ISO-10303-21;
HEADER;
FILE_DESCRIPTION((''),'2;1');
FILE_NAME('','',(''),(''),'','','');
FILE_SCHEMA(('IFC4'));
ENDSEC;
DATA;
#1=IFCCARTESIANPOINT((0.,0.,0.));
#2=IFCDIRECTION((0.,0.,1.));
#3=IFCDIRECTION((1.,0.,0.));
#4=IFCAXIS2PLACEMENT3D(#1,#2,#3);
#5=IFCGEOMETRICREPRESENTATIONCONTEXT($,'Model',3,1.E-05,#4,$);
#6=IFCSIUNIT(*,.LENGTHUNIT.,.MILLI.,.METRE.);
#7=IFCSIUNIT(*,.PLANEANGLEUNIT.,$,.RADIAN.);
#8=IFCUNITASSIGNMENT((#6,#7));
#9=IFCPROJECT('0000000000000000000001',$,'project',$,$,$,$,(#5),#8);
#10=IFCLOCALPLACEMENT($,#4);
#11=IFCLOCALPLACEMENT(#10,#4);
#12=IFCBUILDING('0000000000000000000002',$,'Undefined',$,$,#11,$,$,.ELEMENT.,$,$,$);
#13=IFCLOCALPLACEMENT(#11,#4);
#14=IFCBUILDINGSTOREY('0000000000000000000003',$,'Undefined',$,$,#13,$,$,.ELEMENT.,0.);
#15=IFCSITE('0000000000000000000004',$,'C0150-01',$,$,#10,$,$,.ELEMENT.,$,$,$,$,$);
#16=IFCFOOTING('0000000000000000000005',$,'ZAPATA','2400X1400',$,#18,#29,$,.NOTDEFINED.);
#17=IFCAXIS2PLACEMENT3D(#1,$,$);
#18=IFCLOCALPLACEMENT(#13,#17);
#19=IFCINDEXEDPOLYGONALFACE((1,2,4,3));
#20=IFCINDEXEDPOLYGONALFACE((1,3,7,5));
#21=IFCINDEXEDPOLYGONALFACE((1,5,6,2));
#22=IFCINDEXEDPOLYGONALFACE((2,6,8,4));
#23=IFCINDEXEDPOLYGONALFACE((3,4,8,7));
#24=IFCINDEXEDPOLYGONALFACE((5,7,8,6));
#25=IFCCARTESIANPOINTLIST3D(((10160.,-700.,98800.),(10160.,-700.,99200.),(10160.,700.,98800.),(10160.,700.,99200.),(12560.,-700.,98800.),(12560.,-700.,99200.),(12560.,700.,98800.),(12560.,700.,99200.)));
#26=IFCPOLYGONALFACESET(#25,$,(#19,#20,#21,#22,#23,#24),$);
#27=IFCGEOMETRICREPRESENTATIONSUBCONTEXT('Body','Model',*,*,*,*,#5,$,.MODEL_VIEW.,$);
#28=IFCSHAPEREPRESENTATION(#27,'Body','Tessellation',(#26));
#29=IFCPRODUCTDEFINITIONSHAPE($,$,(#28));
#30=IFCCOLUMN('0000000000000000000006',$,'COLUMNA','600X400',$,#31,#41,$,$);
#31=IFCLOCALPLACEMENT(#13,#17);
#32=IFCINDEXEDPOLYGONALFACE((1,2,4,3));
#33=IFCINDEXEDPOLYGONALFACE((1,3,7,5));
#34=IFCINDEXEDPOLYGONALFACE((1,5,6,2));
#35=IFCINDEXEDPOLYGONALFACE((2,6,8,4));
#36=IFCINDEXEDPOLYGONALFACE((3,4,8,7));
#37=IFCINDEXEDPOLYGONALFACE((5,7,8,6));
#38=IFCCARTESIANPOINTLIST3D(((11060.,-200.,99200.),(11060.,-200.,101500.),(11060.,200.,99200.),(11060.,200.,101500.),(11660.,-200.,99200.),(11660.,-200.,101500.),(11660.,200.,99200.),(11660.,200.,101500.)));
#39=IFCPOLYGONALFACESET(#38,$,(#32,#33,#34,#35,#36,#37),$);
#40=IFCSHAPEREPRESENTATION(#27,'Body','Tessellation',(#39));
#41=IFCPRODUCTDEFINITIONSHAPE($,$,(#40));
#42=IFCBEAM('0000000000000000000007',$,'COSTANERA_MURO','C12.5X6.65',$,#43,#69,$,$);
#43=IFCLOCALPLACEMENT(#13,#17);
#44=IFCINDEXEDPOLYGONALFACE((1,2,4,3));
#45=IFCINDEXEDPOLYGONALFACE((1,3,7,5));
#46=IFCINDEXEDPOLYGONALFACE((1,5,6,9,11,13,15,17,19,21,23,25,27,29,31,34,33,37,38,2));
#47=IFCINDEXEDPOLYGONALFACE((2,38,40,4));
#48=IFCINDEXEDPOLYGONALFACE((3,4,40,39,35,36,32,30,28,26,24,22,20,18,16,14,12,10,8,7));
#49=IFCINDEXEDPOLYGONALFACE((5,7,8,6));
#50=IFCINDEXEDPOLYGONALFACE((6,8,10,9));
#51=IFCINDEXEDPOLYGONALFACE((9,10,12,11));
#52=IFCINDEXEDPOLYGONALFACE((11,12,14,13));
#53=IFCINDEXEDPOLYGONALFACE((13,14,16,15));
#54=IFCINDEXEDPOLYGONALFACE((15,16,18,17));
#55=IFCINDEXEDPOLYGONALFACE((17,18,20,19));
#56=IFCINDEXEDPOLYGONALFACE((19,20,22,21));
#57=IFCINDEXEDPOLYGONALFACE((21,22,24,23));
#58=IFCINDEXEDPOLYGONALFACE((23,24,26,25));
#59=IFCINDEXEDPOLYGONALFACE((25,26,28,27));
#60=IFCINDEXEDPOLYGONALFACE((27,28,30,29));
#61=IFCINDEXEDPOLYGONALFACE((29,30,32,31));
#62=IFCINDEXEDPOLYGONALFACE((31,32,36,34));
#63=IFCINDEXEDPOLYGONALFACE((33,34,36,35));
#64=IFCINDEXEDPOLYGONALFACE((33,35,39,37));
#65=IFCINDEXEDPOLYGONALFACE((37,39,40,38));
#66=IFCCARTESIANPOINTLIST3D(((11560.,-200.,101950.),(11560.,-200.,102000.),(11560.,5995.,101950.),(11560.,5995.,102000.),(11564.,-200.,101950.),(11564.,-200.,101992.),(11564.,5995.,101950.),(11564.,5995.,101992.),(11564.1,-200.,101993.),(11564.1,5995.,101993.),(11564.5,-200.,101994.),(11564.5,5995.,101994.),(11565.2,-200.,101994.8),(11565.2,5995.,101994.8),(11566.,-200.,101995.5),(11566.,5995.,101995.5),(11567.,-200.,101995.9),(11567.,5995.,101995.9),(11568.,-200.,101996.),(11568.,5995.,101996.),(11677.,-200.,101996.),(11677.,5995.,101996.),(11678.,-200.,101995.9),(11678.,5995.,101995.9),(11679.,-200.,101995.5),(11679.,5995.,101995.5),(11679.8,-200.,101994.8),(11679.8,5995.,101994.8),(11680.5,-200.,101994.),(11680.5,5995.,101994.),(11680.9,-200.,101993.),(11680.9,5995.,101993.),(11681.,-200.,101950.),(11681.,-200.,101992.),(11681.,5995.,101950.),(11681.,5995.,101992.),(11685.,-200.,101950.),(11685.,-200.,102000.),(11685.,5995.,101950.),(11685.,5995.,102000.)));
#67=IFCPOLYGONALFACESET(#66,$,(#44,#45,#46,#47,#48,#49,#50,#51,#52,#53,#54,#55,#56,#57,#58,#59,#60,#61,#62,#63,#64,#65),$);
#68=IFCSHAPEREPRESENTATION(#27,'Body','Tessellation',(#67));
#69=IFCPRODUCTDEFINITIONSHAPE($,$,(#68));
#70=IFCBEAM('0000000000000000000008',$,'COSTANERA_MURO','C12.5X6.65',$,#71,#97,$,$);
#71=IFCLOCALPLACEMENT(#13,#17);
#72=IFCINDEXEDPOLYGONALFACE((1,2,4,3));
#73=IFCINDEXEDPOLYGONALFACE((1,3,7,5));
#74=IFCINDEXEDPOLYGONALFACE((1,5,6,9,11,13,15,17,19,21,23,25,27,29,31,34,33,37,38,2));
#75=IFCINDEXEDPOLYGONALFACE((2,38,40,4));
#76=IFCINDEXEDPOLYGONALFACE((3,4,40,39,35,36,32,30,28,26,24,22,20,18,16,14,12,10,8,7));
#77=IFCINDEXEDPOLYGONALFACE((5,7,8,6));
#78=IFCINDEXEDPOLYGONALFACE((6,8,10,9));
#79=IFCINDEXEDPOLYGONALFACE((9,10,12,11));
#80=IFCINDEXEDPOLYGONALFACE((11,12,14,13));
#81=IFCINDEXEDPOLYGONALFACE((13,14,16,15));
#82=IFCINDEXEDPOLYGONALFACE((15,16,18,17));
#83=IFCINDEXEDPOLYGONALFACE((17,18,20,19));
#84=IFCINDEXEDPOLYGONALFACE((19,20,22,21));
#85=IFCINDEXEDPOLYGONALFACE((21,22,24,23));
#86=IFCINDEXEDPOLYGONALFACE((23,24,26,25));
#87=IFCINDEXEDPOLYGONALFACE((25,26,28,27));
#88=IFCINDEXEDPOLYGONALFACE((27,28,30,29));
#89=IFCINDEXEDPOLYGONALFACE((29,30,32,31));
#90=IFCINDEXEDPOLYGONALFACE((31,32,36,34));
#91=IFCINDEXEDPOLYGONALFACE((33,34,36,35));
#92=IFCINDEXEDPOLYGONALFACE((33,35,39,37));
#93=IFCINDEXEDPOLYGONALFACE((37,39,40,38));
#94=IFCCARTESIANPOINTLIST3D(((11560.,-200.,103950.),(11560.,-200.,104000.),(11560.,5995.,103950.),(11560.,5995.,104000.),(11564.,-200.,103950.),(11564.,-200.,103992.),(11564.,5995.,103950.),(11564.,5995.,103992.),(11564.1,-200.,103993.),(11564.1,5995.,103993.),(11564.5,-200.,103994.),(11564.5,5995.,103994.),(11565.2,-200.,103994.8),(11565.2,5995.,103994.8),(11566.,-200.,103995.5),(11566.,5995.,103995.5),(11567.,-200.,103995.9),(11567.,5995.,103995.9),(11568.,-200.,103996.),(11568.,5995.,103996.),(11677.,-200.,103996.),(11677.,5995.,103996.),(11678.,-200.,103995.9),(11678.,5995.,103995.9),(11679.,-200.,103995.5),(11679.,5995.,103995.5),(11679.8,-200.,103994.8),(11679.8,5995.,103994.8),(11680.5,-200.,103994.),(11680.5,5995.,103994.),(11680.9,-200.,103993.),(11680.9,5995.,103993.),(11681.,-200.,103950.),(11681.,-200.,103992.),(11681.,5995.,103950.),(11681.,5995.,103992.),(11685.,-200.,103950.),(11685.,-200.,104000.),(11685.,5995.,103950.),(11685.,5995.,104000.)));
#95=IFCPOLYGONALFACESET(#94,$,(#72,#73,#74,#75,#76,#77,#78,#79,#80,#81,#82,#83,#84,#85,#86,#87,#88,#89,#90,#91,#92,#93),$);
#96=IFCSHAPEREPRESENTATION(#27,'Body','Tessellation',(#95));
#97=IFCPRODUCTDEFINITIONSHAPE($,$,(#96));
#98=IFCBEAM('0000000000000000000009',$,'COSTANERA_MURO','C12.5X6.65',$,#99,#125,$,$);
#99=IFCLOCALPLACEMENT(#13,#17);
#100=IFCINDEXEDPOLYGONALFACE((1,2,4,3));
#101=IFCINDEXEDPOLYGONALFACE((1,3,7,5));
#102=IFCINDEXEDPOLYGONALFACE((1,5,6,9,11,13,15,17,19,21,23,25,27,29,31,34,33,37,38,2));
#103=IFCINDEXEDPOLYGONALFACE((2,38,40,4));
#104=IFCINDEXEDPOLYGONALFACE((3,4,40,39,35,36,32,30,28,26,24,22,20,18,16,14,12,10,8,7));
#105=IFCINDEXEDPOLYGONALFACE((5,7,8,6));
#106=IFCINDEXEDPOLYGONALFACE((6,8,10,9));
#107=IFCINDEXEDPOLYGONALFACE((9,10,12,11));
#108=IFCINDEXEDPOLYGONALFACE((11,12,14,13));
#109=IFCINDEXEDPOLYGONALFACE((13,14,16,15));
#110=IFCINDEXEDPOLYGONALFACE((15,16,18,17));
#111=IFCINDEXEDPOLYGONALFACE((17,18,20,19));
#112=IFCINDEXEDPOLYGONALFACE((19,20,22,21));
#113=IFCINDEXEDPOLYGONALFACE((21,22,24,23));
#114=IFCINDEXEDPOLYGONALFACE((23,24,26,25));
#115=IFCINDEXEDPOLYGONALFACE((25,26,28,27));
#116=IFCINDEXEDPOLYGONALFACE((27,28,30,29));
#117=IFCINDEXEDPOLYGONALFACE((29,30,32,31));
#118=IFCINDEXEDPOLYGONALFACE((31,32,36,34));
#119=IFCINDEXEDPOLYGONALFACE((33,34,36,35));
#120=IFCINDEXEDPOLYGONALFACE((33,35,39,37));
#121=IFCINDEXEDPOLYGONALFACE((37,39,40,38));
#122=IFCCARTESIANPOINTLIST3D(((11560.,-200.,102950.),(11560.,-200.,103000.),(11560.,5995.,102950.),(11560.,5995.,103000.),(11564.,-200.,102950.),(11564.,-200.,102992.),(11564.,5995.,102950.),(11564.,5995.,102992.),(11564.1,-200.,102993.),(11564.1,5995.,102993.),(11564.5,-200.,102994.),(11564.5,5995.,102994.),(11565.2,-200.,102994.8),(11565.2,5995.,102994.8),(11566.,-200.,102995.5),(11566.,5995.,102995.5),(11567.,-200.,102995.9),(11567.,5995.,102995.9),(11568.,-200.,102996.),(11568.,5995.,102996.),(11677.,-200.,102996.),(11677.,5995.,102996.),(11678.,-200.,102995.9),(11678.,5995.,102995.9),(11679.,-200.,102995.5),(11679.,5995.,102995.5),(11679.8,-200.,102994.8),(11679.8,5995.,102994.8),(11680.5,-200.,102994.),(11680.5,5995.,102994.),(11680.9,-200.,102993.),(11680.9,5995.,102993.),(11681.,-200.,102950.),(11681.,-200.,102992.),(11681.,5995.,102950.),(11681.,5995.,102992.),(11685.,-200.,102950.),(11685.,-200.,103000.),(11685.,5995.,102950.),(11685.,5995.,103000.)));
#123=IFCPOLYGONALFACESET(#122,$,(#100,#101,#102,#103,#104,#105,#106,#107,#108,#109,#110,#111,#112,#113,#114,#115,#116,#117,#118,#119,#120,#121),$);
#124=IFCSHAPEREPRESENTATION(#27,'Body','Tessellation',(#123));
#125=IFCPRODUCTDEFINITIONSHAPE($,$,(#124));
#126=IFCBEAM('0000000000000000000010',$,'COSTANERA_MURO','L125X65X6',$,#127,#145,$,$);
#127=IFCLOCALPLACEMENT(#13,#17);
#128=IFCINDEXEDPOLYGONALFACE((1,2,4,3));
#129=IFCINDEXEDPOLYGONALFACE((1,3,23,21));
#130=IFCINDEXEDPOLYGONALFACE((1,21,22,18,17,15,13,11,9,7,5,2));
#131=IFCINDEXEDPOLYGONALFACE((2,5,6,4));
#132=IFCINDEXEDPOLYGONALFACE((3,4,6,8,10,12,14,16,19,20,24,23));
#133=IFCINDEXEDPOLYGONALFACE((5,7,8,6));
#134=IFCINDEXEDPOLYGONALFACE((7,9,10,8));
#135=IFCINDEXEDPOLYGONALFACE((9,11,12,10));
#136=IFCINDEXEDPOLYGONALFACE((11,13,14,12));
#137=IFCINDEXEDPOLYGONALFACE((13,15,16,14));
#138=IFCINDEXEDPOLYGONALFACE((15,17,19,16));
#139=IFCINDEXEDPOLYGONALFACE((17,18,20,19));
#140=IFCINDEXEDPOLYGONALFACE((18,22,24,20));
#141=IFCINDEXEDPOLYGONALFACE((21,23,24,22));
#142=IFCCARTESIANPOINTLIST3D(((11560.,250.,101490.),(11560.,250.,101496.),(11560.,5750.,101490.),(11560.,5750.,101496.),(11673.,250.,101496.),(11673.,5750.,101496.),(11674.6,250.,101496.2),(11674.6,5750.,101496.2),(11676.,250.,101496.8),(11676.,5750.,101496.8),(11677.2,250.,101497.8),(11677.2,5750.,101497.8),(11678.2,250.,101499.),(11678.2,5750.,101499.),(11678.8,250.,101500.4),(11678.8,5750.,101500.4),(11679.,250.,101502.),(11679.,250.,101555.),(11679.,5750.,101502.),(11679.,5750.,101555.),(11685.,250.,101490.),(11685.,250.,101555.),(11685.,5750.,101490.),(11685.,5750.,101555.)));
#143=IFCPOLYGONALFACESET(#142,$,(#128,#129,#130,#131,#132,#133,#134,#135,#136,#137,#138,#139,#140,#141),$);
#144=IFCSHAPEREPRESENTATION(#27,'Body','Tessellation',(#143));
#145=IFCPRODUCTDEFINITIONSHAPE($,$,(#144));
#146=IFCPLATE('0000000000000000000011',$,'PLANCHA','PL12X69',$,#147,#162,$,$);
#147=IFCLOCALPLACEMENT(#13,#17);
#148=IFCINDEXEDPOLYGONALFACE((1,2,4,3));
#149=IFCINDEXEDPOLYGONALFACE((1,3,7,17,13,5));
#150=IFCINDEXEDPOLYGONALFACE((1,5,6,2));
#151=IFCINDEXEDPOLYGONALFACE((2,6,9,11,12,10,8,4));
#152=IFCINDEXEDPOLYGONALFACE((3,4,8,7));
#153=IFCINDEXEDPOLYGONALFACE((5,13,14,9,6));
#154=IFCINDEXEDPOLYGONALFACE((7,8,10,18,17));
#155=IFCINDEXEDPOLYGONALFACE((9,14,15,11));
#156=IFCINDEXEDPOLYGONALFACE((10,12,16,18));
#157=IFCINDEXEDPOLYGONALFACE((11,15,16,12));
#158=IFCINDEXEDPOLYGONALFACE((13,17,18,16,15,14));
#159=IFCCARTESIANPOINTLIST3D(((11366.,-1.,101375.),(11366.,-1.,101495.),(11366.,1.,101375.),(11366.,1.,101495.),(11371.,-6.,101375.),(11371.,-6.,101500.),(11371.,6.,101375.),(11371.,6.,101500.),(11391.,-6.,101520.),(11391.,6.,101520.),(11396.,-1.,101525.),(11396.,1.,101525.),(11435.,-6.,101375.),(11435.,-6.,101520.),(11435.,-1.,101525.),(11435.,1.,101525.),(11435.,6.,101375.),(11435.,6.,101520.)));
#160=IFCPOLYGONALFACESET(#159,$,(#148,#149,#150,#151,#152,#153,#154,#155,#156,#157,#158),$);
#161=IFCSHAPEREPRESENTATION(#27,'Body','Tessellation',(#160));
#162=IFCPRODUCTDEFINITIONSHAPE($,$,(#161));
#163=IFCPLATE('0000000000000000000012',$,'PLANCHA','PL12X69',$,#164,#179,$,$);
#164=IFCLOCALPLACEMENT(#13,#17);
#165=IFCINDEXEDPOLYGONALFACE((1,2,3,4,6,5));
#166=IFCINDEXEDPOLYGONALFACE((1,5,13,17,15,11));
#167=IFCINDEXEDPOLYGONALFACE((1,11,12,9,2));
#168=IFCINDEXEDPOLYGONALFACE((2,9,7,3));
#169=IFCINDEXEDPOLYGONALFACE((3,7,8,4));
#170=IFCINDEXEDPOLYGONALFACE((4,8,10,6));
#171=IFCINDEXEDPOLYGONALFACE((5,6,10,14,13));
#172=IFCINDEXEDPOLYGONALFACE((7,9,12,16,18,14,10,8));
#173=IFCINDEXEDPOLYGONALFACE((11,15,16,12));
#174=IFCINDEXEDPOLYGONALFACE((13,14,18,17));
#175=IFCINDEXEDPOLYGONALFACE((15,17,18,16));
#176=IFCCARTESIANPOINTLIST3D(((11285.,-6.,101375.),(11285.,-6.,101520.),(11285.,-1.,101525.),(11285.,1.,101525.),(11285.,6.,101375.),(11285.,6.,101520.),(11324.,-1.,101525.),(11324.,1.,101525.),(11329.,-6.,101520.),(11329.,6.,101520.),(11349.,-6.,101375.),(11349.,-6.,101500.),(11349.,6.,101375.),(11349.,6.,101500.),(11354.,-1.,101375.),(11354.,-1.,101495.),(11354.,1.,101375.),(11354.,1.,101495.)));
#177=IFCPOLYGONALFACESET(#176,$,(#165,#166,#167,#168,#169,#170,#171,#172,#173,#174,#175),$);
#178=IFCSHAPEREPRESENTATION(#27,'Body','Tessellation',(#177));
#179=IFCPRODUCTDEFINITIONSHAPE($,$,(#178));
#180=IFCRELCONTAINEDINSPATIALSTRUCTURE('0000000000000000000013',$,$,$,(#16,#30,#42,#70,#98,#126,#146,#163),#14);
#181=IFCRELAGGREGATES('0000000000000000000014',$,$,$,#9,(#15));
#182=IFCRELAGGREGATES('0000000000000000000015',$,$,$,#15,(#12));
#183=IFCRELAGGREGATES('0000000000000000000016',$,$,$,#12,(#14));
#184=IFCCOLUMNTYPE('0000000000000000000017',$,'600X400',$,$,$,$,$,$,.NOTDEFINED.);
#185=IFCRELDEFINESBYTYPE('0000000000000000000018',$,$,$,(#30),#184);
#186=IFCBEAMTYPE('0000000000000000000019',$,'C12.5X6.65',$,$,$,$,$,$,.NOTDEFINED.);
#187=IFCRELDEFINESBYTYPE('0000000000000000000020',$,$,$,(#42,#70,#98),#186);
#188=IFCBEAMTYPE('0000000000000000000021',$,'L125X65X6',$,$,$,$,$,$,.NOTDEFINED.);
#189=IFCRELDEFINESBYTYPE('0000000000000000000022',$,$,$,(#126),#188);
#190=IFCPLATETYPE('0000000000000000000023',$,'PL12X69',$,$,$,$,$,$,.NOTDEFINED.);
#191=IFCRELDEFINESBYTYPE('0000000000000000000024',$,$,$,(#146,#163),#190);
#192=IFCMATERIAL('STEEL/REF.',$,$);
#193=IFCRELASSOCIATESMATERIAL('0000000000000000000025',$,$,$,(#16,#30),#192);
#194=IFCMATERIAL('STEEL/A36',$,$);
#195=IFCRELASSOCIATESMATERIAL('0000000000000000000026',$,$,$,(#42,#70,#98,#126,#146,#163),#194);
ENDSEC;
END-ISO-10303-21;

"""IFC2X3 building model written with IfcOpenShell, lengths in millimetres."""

from ifc_helpers import new_model, si_unit, frame, origin_with_axes, origin_2d_with_axis, place, context, subcontext, project, spatial, polyline, rectangle, l_section, u_section, outline, extrude, boolean, material, type_object, element, save


model = new_model("IFC2X3")

# Units and contexts
model_context = context("Model", 3, precision=1e-05, world=origin_with_axes())
body_context = subcontext(model_context, "Body", "Model", "MODEL_VIEW")
ifc_project = project(units=[si_unit("LENGTHUNIT", "METRE", prefix="MILLI"), si_unit("PLANEANGLEUNIT", "RADIAN")], contexts=[model_context])

# Site, building, storey
site_placement = place(None, origin_with_axes())
site = spatial("IfcSite", under=ifc_project, at=site_placement, Name="C0150-01", CompositionType="ELEMENT")
building_placement = place(site_placement, origin_with_axes())
building = spatial("IfcBuilding", under=site, at=building_placement, Name="Undefined", CompositionType="ELEMENT")
storey_placement = place(building_placement, origin_with_axes())
storey = spatial("IfcBuildingStorey", under=building, at=storey_placement, Name="Undefined", CompositionType="ELEMENT", Elevation=0.0)

# Footing
ifc_material_1 = material(Name="STEEL/REF.")
footing_placement = place(storey_placement, frame((11360.0, 0.0, 98800.0), z_axis=(-1.0, 0.0, 0.0), x_axis=(0.0, 0.0, 1.0)))
element("IfcFooting", 1, at=footing_placement, inside=storey, material=ifc_material_1, Name="ZAPATA", Description="2400X1400", PredefinedType="NOTDEFINED", context=body_context, shape_type="SweptSolid", body=[
    extrude(rectangle(XDim=1400.0, YDim=2400.0, at=origin_2d_with_axis()), frame((400.0, 0.0, 0.0), z_axis=(-1.0, 0.0, 0.0), x_axis=(0.0, -1.0, 0.0)), (0.0, 0.0, 1.0), 400.0),
])

# Column
column_type_1 = type_object("IfcColumnType", Name="600X400", PredefinedType="NOTDEFINED")
column_1_placement = place(storey_placement, frame((11360.0, 0.0, 99200.0), z_axis=(0.0, 0.0, 1.0), x_axis=(-1.0, 0.0, 0.0)))
element("IfcColumn", 2, at=column_1_placement, inside=storey, type_object=column_type_1, material=ifc_material_1, Name="COLUMNA", Description="600X400", context=body_context, shape_type="SweptSolid", body=[
    extrude(rectangle(XDim=400.0, YDim=600.0, at=origin_2d_with_axis()), frame((0.0, 0.0, 2300.0), z_axis=(0.0, 0.0, -1.0), x_axis=(0.0, 1.0, 0.0)), (0.0, 0.0, 1.0), 2300.0),
])
ifc_material_2 = material(Name="STEEL/A36")

# Beams
beam_type_1 = type_object("IfcBeamType", Name="C12.5X6.65", PredefinedType="NOTDEFINED")
for number, where, z_axis, x_axis, name in (
    (3, (11622.5, -200.0, 101975.0), (1.0, 0.0, 0.0), (0.0, 1.0, 0.0), "COSTANERA_MURO"),
    (4, (11622.5, -200.0, 103975.0), (1.0, 0.0, 0.0), (0.0, 1.0, 0.0), "COSTANERA_MURO"),
    (5, (11622.5, -200.0, 102975.0), (1.0, 0.0, 0.0), (0.0, 1.0, 0.0), "COSTANERA_MURO"),
):
    element("IfcBeam", number, at=place(storey_placement, frame(where, z_axis=z_axis, x_axis=x_axis)), inside=storey, type_object=beam_type_1, material=ifc_material_2, Name=name, Description="C12.5X6.65", context=body_context, shape_type="SweptSolid", body=[
        extrude(u_section(Depth=125.0, FlangeWidth=50.0, WebThickness=4.0, FlangeThickness=4.0, FilletRadius=4.0, at=origin_2d_with_axis()), frame((6195.0, 0.0, 0.0), z_axis=(-1.0, 0.0, 0.0), x_axis=(0.0, -1.0, 0.0)), (0.0, 0.0, 1.0), 6195.0),
    ])
beam_type_2 = type_object("IfcBeamType", Name="L125X65X6", PredefinedType="NOTDEFINED")
beam_placement = place(storey_placement, frame((11622.5, 250.0, 101522.5), z_axis=(-1.0, 0.0, 0.0), x_axis=(0.0, 1.0, 0.0)))
element("IfcBeam", 6, at=beam_placement, inside=storey, type_object=beam_type_2, material=ifc_material_2, Name="COSTANERA_MURO", Description="L125X65X6", context=body_context, shape_type="SweptSolid", body=[
    extrude(l_section(Depth=125.0, Width=65.0, Thickness=6.0, FilletRadius=6.0, at=origin_2d_with_axis()), frame((5500.0, 0.0, 0.0), z_axis=(-1.0, 0.0, 0.0), x_axis=(0.0, -1.0, 0.0)), (0.0, 0.0, 1.0), 5500.0),
])

# Plates
plate_type_1 = type_object("IfcPlateType", Name="PL12X69", PredefinedType="NOTDEFINED")
plate_1_placement = place(storey_placement, frame((11435.0, 0.0, 101525.0), z_axis=(0.0, 1.0, 0.0), x_axis=(0.0, 0.0, -1.0)))
element("IfcPlate", 7, at=plate_1_placement, inside=storey, type_object=plate_type_1, material=ifc_material_2, Name="PLANCHA", Description="PL12X69", context=body_context, shape_type="CSG", body=[
    boolean("DIFFERENCE", boolean("DIFFERENCE", boolean("DIFFERENCE", boolean("DIFFERENCE", extrude(outline(polyline([(0.0, 0.0), (150.0, 0.0), (150.0, 69.0), (30.0, 69.0), (0.0, 39.0), (0.0, 0.0)])), frame((0.0, 0.0, -6.0), z_axis=(0.0, 0.0, 1.0), x_axis=(1.0, 0.0, 0.0)), (0.0, 0.0, 1.0), 12.0), extrude(outline(polyline([(0.0, 0.0), (5.0, 0.0), (5.0, 5.0), (0.0, 0.0)])), frame((-2.5, 69.0, 1.0), z_axis=(1.0, 0.0, 0.0), x_axis=(0.0, 0.0, 1.0)), (0.0, 0.0, 1.0), 155.0)), extrude(outline(polyline([(0.0, 0.0), (5.0, 0.0), (5.0, 5.0), (0.0, 0.0)])), frame((152.5, 69.0, -1.0), z_axis=(-1.0, 0.0, 0.0), x_axis=(0.0, 0.0, -1.0)), (0.0, 0.0, 1.0), 155.0)), extrude(outline(polyline([(0.0, 0.0), (5.0, 0.0), (5.0, 5.0), (0.0, 0.0)])), frame((0.0, -29.5, 1.0), z_axis=(0.0, 1.0, 0.0), x_axis=(0.0, 0.0, 1.0)), (0.0, 0.0, 1.0), 101.0)), extrude(outline(polyline([(0.0, 0.0), (5.0, 0.0), (5.0, 5.0), (0.0, 0.0)])), frame((0.0, 71.5, -1.0), z_axis=(0.0, -1.0, 0.0), x_axis=(0.0, 0.0, -1.0)), (0.0, 0.0, 1.0), 101.0)),
])
plate_2_placement = place(storey_placement, frame((11285.0, 0.0, 101525.0), z_axis=(0.0, -1.0, 0.0), x_axis=(0.0, 0.0, -1.0)))
element("IfcPlate", 8, at=plate_2_placement, inside=storey, type_object=plate_type_1, material=ifc_material_2, Name="PLANCHA", Description="PL12X69", context=body_context, shape_type="CSG", body=[
    boolean("DIFFERENCE", boolean("DIFFERENCE", boolean("DIFFERENCE", boolean("DIFFERENCE", extrude(outline(polyline([(0.0, 0.0), (150.0, 0.0), (150.0, 69.0), (30.0, 69.0), (0.0, 39.0), (0.0, 0.0)])), frame((0.0, 0.0, -6.0), z_axis=(0.0, 0.0, 1.0), x_axis=(1.0, 0.0, 0.0)), (0.0, 0.0, 1.0), 12.0), extrude(outline(polyline([(0.0, 0.0), (5.0, 0.0), (5.0, 5.0), (0.0, 0.0)])), frame((152.5, 69.0, -1.0), z_axis=(-1.0, 0.0, 0.0), x_axis=(0.0, 0.0, -1.0)), (0.0, 0.0, 1.0), 155.0)), extrude(outline(polyline([(0.0, 0.0), (5.0, 0.0), (5.0, 5.0), (0.0, 0.0)])), frame((-2.5, 69.0, 1.0), z_axis=(1.0, 0.0, 0.0), x_axis=(0.0, 0.0, 1.0)), (0.0, 0.0, 1.0), 155.0)), extrude(outline(polyline([(0.0, 0.0), (5.0, 0.0), (5.0, 5.0), (0.0, 0.0)])), frame((0.0, 71.5, -1.0), z_axis=(0.0, -1.0, 0.0), x_axis=(0.0, 0.0, -1.0)), (0.0, 0.0, 1.0), 101.0)), extrude(outline(polyline([(0.0, 0.0), (5.0, 0.0), (5.0, 5.0), (0.0, 0.0)])), frame((0.0, -29.5, 1.0), z_axis=(0.0, 1.0, 0.0), x_axis=(0.0, 0.0, 1.0)), (0.0, 0.0, 1.0), 101.0)),
])

save(model, "model.ifc")
